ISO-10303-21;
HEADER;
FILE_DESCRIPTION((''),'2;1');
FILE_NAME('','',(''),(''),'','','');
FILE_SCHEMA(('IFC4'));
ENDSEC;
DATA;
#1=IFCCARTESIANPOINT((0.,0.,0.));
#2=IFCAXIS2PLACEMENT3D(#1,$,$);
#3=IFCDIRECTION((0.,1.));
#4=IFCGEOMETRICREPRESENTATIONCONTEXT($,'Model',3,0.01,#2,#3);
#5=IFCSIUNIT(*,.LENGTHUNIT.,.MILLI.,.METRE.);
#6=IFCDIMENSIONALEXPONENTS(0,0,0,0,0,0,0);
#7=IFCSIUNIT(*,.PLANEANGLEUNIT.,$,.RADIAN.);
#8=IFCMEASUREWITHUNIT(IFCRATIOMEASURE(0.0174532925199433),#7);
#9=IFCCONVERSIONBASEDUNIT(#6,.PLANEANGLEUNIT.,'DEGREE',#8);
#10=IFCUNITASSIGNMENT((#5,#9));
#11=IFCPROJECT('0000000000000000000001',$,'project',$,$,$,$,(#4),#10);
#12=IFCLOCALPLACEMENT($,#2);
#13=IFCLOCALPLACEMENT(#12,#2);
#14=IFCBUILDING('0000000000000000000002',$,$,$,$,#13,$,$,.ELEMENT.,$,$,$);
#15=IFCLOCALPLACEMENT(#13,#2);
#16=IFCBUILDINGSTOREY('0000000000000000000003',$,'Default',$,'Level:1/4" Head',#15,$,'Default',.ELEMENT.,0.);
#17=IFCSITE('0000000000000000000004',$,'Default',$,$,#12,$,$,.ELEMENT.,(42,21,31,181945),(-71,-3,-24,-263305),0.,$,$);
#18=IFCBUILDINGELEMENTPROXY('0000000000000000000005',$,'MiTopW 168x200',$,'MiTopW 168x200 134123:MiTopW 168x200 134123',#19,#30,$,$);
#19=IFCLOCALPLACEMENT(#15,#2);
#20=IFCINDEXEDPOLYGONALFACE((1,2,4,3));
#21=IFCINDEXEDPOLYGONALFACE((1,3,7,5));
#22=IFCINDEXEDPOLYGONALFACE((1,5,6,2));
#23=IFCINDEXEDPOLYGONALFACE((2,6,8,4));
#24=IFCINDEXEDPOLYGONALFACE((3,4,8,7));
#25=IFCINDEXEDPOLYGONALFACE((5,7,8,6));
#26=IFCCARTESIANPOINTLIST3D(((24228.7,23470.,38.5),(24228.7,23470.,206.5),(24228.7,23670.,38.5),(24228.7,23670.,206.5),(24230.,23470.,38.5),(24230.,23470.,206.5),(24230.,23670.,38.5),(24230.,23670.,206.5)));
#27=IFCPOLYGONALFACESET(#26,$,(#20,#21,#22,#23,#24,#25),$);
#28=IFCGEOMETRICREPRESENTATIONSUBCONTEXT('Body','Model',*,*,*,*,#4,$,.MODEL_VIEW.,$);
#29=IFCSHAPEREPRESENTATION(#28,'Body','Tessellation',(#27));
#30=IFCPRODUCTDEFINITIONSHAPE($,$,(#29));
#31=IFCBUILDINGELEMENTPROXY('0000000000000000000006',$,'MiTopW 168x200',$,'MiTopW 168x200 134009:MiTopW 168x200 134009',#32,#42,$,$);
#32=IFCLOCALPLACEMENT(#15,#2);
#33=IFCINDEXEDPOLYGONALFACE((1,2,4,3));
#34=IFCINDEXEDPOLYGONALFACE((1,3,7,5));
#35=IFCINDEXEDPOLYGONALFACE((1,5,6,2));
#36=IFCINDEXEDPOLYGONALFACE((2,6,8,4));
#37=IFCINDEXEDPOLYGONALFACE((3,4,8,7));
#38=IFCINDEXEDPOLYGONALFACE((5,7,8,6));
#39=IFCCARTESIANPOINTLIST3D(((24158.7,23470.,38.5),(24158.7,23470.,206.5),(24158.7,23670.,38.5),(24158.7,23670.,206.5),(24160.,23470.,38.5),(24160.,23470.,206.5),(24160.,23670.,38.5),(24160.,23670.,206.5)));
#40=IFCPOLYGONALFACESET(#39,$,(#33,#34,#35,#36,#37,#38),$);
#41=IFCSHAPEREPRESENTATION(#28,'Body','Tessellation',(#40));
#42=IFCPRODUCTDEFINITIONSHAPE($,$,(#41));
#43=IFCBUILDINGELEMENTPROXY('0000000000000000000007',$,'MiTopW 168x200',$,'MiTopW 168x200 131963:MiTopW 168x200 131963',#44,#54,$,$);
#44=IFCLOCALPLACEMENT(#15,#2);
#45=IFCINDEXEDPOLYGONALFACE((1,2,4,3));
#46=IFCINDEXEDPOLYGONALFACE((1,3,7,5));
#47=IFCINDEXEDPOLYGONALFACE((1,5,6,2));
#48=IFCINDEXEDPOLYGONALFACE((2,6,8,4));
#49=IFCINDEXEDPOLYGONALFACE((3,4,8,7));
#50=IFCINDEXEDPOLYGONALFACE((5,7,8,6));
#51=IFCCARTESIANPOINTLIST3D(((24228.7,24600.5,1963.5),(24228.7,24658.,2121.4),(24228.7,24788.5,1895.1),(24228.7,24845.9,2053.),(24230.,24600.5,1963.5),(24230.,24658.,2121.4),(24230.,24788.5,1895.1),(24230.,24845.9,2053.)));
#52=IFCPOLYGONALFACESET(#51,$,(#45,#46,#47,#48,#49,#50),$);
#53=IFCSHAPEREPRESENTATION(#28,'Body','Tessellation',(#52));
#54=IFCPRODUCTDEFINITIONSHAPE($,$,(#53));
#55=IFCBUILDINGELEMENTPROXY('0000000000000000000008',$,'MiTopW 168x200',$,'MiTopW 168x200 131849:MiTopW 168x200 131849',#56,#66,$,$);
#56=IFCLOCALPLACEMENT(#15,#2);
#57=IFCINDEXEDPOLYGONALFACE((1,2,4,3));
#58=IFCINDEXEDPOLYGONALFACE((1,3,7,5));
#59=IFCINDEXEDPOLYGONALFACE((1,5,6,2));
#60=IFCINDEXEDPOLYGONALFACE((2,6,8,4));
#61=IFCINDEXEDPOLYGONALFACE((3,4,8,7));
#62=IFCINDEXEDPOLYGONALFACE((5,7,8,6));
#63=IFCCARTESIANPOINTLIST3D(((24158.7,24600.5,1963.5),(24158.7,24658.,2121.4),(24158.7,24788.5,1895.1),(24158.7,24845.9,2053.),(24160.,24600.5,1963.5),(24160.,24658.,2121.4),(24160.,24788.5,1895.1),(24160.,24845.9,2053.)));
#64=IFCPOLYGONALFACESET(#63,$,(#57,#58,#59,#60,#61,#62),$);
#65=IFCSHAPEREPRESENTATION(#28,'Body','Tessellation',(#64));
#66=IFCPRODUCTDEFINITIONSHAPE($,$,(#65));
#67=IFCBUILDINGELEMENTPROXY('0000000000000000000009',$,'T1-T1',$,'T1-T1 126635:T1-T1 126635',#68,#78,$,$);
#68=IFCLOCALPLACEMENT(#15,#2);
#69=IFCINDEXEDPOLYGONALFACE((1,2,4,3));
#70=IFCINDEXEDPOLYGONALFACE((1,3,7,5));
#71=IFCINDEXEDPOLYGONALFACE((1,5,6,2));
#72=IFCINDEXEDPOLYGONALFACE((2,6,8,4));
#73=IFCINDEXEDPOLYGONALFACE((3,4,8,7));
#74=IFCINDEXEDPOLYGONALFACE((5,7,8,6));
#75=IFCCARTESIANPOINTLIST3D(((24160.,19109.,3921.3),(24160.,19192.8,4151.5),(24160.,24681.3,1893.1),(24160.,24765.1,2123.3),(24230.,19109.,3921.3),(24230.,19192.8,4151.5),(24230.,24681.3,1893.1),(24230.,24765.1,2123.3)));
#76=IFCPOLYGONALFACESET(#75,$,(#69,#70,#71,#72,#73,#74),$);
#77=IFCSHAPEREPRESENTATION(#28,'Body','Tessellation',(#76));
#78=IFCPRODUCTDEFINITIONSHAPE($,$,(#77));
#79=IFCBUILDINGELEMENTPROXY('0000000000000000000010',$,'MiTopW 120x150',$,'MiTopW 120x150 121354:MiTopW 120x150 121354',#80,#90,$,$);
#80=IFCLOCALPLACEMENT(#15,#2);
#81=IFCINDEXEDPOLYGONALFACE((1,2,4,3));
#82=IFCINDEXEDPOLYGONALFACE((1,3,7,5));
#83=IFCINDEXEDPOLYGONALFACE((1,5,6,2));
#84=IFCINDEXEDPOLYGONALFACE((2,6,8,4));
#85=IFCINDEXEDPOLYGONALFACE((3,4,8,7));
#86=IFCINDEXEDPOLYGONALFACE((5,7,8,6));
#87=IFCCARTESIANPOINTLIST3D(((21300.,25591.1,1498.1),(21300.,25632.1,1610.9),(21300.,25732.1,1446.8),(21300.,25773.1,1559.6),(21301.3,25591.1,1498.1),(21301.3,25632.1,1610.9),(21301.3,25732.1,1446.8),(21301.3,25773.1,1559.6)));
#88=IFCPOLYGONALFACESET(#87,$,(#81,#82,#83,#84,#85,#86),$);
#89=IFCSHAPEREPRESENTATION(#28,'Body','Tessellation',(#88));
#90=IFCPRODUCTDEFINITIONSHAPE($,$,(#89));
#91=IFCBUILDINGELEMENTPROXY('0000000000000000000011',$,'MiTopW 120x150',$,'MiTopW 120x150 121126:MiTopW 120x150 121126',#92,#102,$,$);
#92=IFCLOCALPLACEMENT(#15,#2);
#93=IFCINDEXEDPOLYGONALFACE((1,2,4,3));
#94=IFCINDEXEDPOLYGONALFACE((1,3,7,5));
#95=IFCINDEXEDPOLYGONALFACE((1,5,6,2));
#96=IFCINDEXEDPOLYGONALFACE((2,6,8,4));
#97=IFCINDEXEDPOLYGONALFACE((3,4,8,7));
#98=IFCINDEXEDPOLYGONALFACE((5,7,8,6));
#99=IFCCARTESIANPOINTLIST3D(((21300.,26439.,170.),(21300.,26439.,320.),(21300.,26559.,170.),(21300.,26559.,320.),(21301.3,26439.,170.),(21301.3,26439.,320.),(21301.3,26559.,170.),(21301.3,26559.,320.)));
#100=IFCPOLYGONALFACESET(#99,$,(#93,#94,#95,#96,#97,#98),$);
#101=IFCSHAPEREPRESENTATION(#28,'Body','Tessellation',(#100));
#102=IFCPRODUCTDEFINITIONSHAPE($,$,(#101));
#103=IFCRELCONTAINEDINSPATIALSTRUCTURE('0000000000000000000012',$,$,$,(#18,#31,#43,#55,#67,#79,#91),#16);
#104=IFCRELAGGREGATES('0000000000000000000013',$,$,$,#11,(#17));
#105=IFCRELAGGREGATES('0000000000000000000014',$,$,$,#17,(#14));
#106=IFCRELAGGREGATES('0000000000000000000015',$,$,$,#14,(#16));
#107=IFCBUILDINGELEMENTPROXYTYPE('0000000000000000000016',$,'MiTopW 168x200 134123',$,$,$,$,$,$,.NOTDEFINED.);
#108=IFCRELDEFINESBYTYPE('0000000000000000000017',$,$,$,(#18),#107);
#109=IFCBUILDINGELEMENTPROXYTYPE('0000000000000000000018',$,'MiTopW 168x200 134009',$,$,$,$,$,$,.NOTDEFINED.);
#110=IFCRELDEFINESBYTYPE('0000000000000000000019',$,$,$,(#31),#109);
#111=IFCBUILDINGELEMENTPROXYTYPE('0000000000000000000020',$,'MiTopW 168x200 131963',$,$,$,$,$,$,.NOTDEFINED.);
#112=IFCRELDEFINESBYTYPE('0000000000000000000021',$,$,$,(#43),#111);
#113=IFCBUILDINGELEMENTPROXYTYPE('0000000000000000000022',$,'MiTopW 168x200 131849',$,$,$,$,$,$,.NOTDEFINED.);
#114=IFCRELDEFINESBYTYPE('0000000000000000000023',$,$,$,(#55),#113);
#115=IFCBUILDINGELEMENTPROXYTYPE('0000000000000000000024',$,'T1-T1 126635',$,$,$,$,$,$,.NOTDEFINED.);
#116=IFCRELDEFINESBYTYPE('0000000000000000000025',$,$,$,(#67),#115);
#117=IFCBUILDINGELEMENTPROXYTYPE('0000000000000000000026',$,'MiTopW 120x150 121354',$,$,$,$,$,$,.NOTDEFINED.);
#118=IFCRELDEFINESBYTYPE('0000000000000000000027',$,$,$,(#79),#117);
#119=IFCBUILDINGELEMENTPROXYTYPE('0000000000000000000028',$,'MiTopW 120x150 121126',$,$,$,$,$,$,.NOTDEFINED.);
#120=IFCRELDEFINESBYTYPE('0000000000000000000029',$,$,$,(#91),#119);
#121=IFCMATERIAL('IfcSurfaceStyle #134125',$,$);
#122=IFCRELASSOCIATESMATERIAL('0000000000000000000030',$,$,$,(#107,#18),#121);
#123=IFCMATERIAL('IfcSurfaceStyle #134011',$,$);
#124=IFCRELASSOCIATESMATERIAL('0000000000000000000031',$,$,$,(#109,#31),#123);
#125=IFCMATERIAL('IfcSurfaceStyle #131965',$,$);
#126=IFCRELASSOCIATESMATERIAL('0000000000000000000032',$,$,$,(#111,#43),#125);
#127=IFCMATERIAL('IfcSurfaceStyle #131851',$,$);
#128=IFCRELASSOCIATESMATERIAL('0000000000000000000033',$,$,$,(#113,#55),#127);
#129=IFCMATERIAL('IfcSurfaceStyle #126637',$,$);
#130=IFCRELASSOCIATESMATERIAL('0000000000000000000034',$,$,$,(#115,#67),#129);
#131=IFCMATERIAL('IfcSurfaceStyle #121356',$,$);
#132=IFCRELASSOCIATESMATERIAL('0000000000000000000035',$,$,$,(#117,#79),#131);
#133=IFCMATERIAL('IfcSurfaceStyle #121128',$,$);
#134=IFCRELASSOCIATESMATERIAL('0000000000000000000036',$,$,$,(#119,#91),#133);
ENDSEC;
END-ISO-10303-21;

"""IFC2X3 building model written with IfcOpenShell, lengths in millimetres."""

from ifc_helpers import new_model, entity, si_unit, converted_unit, direction, frame, frame_2d, origin, origin_2d_with_axis, place, context, subcontext, project, spatial, polyline, rectangle, outline, extrude, source, transform, mapped, material, type_object, type_shapes, element, save


model = new_model("IFC2X3")

# Units and contexts
model_context = context("Model", 3, precision=0.01, world=origin(), true_north=direction((0.0, 1.0)))
body_context = subcontext(model_context, "Body", "Model", "MODEL_VIEW")
ifc_project = project(units=[si_unit("LENGTHUNIT", "METRE", prefix="MILLI"), converted_unit("PLANEANGLEUNIT", "DEGREE", entity("IfcRatioMeasure", 0.0174532925199433), si_unit("PLANEANGLEUNIT", "RADIAN"), dimensions=[0, 0, 0, 0, 0, 0, 0])], contexts=[model_context])

# Site, building, storey
site_placement = place(None, origin())
site = spatial("IfcSite", under=ifc_project, at=site_placement, Name="Default", CompositionType="ELEMENT", RefLatitude=(42, 21, 31, 181945), RefLongitude=(-71, -3, -24, -263305), RefElevation=0.0)
building_placement = place(site_placement, origin())
building = spatial("IfcBuilding", under=site, at=building_placement, CompositionType="ELEMENT")
storey_placement = place(building_placement, origin())
storey = spatial("IfcBuildingStorey", under=building, at=storey_placement, Name="Default", ObjectType="Level:1/4\" Head", LongName="Default", CompositionType="ELEMENT", Elevation=0.0)

# Building element proxies
ifc_material_1 = material(Name="IfcSurfaceStyle #134125")
building_element_proxy_type_1 = type_object("IfcBuildingElementProxyType", Name="MiTopW 168x200 134123", PredefinedType="NOTDEFINED", material=ifc_material_1)
shared_shape_1 = source(origin(), body_context, "Body", "SweptSolid", [
    extrude(rectangle(XDim=200.0, YDim=168.0, at=origin_2d_with_axis()), frame((100.0, 84.0, 0.0), z_axis=(0.0, 0.0, 1.0), x_axis=(-1.0, 0.0, 0.0)), (0.0, 0.0, 1.0), 1.3),
])
type_shapes(building_element_proxy_type_1, [shared_shape_1])
proxy_1_placement = place(building_placement, frame((24230.0, 23470.0, 206.5), z_axis=(-1.0, 0.0, 0.0), x_axis=(0.0, 1.0, 0.0)))
element("IfcBuildingElementProxy", 1, at=proxy_1_placement, inside=storey, type_object=building_element_proxy_type_1, material=ifc_material_1, Name="MiTopW 168x200", ObjectType="MiTopW 168x200 134123:MiTopW 168x200 134123", context=body_context, shape_type="MappedRepresentation", body=[
    mapped(shared_shape_1, transform((0.0, 0.0, 0.0), scale=1.0)),
])
ifc_material_2 = material(Name="IfcSurfaceStyle #134011")
building_element_proxy_type_2 = type_object("IfcBuildingElementProxyType", Name="MiTopW 168x200 134009", PredefinedType="NOTDEFINED", material=ifc_material_2)
shared_shape_2 = source(origin(), body_context, "Body", "SweptSolid", [
    extrude(rectangle(XDim=200.0, YDim=168.0, at=origin_2d_with_axis()), frame((100.0, 84.0, 0.0), z_axis=(0.0, 0.0, 1.0), x_axis=(-1.0, 0.0, 0.0)), (0.0, 0.0, 1.0), 1.3),
])
type_shapes(building_element_proxy_type_2, [shared_shape_2])
proxy_2_placement = place(building_placement, frame((24160.0, 23470.0, 206.5), z_axis=(-1.0, 0.0, 0.0), x_axis=(0.0, 1.0, 0.0)))
element("IfcBuildingElementProxy", 2, at=proxy_2_placement, inside=storey, type_object=building_element_proxy_type_2, material=ifc_material_2, Name="MiTopW 168x200", ObjectType="MiTopW 168x200 134009:MiTopW 168x200 134009", context=body_context, shape_type="MappedRepresentation", body=[
    mapped(shared_shape_2, transform((0.0, 0.0, 0.0), scale=1.0)),
])
ifc_material_3 = material(Name="IfcSurfaceStyle #131965")
building_element_proxy_type_3 = type_object("IfcBuildingElementProxyType", Name="MiTopW 168x200 131963", PredefinedType="NOTDEFINED", material=ifc_material_3)
shared_shape_3 = source(origin(), body_context, "Body", "SweptSolid", [
    extrude(outline(polyline([(-100.0, -84.0), (100.0, -84.0), (100.0, 84.0), (-100.0, 84.0), (-100.0, -84.0)])), frame((100.0, 84.0, 0.0), z_axis=(0.0, 0.0, 1.0), x_axis=(-1.0, 0.0, 0.0)), (0.0, 0.0, 1.0), 1.3),
])
type_shapes(building_element_proxy_type_3, [shared_shape_3])
proxy_3_placement = place(building_placement, frame((24230.0, 24788.5, 1895.1), z_axis=(-1.0, 0.0, 0.0), x_axis=(0.0, -0.939693, 0.34202)))
element("IfcBuildingElementProxy", 3, at=proxy_3_placement, inside=storey, type_object=building_element_proxy_type_3, material=ifc_material_3, Name="MiTopW 168x200", ObjectType="MiTopW 168x200 131963:MiTopW 168x200 131963", context=body_context, shape_type="MappedRepresentation", body=[
    mapped(shared_shape_3, transform((0.0, 0.0, 0.0), scale=1.0)),
])
ifc_material_4 = material(Name="IfcSurfaceStyle #131851")
building_element_proxy_type_4 = type_object("IfcBuildingElementProxyType", Name="MiTopW 168x200 131849", PredefinedType="NOTDEFINED", material=ifc_material_4)
shared_shape_4 = source(origin(), body_context, "Body", "SweptSolid", [
    extrude(outline(polyline([(-100.0, -84.0), (100.0, -84.0), (100.0, 84.0), (-100.0, 84.0), (-100.0, -84.0)])), frame((100.0, 84.0, 0.0), z_axis=(0.0, 0.0, 1.0), x_axis=(-1.0, 0.0, 0.0)), (0.0, 0.0, 1.0), 1.3),
])
type_shapes(building_element_proxy_type_4, [shared_shape_4])
proxy_4_placement = place(building_placement, frame((24160.0, 24788.5, 1895.1), z_axis=(-1.0, 0.0, 0.0), x_axis=(0.0, -0.939693, 0.34202)))
element("IfcBuildingElementProxy", 4, at=proxy_4_placement, inside=storey, type_object=building_element_proxy_type_4, material=ifc_material_4, Name="MiTopW 168x200", ObjectType="MiTopW 168x200 131849:MiTopW 168x200 131849", context=body_context, shape_type="MappedRepresentation", body=[
    mapped(shared_shape_4, transform((0.0, 0.0, 0.0), scale=1.0)),
])
ifc_material_5 = material(Name="IfcSurfaceStyle #126637")
building_element_proxy_type_5 = type_object("IfcBuildingElementProxyType", Name="T1-T1 126635", PredefinedType="NOTDEFINED", material=ifc_material_5)
shared_shape_5 = source(origin(), body_context, "Body", "SweptSolid", [
    extrude(outline(polyline([(-2965.0, -122.5), (2965.0, -122.5), (2965.0, 122.5), (-2965.0, 122.5), (-2965.0, -122.5)])), frame((2965.0, 122.5, 0.0), z_axis=(0.0, 0.0, 1.0), x_axis=(-1.0, 0.0, 0.0)), (0.0, 0.0, 1.0), 70.0),
])
type_shapes(building_element_proxy_type_5, [shared_shape_5])
proxy_5_placement = place(building_placement, frame((24230.0, 24681.3, 1893.1), z_axis=(-1.0, 0.0, 0.0), x_axis=(0.0, -0.939693, 0.34202)))
element("IfcBuildingElementProxy", 5, at=proxy_5_placement, inside=storey, type_object=building_element_proxy_type_5, material=ifc_material_5, Name="T1-T1", ObjectType="T1-T1 126635:T1-T1 126635", context=body_context, shape_type="MappedRepresentation", body=[
    mapped(shared_shape_5, transform((0.0, 0.0, 0.0), scale=1.0)),
])
ifc_material_6 = material(Name="IfcSurfaceStyle #121356")
building_element_proxy_type_6 = type_object("IfcBuildingElementProxyType", Name="MiTopW 120x150 121354", PredefinedType="NOTDEFINED", material=ifc_material_6)
shared_shape_6 = source(origin(), body_context, "Body", "SweptSolid", [
    extrude(outline(polyline([(-75.0, -60.0), (75.0, -60.0), (75.0, 60.0), (-75.0, 60.0), (-75.0, -60.0)])), frame((75.0, 60.0, 0.0), z_axis=(0.0, 0.0, 1.0), x_axis=(-1.0, 0.0, 0.0)), (0.0, 0.0, 1.0), 1.3),
])
type_shapes(building_element_proxy_type_6, [shared_shape_6])
proxy_6_placement = place(building_placement, frame((21301.3, 25732.1, 1446.8), z_axis=(-1.0, 0.0, 0.0), x_axis=(0.0, -0.939693, 0.34202)))
element("IfcBuildingElementProxy", 6, at=proxy_6_placement, inside=storey, type_object=building_element_proxy_type_6, material=ifc_material_6, Name="MiTopW 120x150", ObjectType="MiTopW 120x150 121354:MiTopW 120x150 121354", context=body_context, shape_type="MappedRepresentation", body=[
    mapped(shared_shape_6, transform((0.0, 0.0, 0.0), scale=1.0)),
])
ifc_material_7 = material(Name="IfcSurfaceStyle #121128")
building_element_proxy_type_7 = type_object("IfcBuildingElementProxyType", Name="MiTopW 120x150 121126", PredefinedType="NOTDEFINED", material=ifc_material_7)
shared_shape_7 = source(origin(), body_context, "Body", "SweptSolid", [
    extrude(rectangle(XDim=150.0, YDim=120.0, at=frame_2d((0.0, 0.0), x_axis=(1.0, 0.0))), frame((75.0, 60.0, 0.0), z_axis=(0.0, 0.0, 1.0), x_axis=(-1.0, 0.0, 0.0)), (0.0, 0.0, 1.0), 1.3),
])
type_shapes(building_element_proxy_type_7, [shared_shape_7])
proxy_7_placement = place(building_placement, frame((21301.3, 26439.0, 170.0), z_axis=(-1.0, 0.0, 0.0), x_axis=(0.0, 0.0, 1.0)))
element("IfcBuildingElementProxy", 7, at=proxy_7_placement, inside=storey, type_object=building_element_proxy_type_7, material=ifc_material_7, Name="MiTopW 120x150", ObjectType="MiTopW 120x150 121126:MiTopW 120x150 121126", context=body_context, shape_type="MappedRepresentation", body=[
    mapped(shared_shape_7, transform((0.0, 0.0, 0.0), scale=1.0)),
])

save(model, "model.ifc")
